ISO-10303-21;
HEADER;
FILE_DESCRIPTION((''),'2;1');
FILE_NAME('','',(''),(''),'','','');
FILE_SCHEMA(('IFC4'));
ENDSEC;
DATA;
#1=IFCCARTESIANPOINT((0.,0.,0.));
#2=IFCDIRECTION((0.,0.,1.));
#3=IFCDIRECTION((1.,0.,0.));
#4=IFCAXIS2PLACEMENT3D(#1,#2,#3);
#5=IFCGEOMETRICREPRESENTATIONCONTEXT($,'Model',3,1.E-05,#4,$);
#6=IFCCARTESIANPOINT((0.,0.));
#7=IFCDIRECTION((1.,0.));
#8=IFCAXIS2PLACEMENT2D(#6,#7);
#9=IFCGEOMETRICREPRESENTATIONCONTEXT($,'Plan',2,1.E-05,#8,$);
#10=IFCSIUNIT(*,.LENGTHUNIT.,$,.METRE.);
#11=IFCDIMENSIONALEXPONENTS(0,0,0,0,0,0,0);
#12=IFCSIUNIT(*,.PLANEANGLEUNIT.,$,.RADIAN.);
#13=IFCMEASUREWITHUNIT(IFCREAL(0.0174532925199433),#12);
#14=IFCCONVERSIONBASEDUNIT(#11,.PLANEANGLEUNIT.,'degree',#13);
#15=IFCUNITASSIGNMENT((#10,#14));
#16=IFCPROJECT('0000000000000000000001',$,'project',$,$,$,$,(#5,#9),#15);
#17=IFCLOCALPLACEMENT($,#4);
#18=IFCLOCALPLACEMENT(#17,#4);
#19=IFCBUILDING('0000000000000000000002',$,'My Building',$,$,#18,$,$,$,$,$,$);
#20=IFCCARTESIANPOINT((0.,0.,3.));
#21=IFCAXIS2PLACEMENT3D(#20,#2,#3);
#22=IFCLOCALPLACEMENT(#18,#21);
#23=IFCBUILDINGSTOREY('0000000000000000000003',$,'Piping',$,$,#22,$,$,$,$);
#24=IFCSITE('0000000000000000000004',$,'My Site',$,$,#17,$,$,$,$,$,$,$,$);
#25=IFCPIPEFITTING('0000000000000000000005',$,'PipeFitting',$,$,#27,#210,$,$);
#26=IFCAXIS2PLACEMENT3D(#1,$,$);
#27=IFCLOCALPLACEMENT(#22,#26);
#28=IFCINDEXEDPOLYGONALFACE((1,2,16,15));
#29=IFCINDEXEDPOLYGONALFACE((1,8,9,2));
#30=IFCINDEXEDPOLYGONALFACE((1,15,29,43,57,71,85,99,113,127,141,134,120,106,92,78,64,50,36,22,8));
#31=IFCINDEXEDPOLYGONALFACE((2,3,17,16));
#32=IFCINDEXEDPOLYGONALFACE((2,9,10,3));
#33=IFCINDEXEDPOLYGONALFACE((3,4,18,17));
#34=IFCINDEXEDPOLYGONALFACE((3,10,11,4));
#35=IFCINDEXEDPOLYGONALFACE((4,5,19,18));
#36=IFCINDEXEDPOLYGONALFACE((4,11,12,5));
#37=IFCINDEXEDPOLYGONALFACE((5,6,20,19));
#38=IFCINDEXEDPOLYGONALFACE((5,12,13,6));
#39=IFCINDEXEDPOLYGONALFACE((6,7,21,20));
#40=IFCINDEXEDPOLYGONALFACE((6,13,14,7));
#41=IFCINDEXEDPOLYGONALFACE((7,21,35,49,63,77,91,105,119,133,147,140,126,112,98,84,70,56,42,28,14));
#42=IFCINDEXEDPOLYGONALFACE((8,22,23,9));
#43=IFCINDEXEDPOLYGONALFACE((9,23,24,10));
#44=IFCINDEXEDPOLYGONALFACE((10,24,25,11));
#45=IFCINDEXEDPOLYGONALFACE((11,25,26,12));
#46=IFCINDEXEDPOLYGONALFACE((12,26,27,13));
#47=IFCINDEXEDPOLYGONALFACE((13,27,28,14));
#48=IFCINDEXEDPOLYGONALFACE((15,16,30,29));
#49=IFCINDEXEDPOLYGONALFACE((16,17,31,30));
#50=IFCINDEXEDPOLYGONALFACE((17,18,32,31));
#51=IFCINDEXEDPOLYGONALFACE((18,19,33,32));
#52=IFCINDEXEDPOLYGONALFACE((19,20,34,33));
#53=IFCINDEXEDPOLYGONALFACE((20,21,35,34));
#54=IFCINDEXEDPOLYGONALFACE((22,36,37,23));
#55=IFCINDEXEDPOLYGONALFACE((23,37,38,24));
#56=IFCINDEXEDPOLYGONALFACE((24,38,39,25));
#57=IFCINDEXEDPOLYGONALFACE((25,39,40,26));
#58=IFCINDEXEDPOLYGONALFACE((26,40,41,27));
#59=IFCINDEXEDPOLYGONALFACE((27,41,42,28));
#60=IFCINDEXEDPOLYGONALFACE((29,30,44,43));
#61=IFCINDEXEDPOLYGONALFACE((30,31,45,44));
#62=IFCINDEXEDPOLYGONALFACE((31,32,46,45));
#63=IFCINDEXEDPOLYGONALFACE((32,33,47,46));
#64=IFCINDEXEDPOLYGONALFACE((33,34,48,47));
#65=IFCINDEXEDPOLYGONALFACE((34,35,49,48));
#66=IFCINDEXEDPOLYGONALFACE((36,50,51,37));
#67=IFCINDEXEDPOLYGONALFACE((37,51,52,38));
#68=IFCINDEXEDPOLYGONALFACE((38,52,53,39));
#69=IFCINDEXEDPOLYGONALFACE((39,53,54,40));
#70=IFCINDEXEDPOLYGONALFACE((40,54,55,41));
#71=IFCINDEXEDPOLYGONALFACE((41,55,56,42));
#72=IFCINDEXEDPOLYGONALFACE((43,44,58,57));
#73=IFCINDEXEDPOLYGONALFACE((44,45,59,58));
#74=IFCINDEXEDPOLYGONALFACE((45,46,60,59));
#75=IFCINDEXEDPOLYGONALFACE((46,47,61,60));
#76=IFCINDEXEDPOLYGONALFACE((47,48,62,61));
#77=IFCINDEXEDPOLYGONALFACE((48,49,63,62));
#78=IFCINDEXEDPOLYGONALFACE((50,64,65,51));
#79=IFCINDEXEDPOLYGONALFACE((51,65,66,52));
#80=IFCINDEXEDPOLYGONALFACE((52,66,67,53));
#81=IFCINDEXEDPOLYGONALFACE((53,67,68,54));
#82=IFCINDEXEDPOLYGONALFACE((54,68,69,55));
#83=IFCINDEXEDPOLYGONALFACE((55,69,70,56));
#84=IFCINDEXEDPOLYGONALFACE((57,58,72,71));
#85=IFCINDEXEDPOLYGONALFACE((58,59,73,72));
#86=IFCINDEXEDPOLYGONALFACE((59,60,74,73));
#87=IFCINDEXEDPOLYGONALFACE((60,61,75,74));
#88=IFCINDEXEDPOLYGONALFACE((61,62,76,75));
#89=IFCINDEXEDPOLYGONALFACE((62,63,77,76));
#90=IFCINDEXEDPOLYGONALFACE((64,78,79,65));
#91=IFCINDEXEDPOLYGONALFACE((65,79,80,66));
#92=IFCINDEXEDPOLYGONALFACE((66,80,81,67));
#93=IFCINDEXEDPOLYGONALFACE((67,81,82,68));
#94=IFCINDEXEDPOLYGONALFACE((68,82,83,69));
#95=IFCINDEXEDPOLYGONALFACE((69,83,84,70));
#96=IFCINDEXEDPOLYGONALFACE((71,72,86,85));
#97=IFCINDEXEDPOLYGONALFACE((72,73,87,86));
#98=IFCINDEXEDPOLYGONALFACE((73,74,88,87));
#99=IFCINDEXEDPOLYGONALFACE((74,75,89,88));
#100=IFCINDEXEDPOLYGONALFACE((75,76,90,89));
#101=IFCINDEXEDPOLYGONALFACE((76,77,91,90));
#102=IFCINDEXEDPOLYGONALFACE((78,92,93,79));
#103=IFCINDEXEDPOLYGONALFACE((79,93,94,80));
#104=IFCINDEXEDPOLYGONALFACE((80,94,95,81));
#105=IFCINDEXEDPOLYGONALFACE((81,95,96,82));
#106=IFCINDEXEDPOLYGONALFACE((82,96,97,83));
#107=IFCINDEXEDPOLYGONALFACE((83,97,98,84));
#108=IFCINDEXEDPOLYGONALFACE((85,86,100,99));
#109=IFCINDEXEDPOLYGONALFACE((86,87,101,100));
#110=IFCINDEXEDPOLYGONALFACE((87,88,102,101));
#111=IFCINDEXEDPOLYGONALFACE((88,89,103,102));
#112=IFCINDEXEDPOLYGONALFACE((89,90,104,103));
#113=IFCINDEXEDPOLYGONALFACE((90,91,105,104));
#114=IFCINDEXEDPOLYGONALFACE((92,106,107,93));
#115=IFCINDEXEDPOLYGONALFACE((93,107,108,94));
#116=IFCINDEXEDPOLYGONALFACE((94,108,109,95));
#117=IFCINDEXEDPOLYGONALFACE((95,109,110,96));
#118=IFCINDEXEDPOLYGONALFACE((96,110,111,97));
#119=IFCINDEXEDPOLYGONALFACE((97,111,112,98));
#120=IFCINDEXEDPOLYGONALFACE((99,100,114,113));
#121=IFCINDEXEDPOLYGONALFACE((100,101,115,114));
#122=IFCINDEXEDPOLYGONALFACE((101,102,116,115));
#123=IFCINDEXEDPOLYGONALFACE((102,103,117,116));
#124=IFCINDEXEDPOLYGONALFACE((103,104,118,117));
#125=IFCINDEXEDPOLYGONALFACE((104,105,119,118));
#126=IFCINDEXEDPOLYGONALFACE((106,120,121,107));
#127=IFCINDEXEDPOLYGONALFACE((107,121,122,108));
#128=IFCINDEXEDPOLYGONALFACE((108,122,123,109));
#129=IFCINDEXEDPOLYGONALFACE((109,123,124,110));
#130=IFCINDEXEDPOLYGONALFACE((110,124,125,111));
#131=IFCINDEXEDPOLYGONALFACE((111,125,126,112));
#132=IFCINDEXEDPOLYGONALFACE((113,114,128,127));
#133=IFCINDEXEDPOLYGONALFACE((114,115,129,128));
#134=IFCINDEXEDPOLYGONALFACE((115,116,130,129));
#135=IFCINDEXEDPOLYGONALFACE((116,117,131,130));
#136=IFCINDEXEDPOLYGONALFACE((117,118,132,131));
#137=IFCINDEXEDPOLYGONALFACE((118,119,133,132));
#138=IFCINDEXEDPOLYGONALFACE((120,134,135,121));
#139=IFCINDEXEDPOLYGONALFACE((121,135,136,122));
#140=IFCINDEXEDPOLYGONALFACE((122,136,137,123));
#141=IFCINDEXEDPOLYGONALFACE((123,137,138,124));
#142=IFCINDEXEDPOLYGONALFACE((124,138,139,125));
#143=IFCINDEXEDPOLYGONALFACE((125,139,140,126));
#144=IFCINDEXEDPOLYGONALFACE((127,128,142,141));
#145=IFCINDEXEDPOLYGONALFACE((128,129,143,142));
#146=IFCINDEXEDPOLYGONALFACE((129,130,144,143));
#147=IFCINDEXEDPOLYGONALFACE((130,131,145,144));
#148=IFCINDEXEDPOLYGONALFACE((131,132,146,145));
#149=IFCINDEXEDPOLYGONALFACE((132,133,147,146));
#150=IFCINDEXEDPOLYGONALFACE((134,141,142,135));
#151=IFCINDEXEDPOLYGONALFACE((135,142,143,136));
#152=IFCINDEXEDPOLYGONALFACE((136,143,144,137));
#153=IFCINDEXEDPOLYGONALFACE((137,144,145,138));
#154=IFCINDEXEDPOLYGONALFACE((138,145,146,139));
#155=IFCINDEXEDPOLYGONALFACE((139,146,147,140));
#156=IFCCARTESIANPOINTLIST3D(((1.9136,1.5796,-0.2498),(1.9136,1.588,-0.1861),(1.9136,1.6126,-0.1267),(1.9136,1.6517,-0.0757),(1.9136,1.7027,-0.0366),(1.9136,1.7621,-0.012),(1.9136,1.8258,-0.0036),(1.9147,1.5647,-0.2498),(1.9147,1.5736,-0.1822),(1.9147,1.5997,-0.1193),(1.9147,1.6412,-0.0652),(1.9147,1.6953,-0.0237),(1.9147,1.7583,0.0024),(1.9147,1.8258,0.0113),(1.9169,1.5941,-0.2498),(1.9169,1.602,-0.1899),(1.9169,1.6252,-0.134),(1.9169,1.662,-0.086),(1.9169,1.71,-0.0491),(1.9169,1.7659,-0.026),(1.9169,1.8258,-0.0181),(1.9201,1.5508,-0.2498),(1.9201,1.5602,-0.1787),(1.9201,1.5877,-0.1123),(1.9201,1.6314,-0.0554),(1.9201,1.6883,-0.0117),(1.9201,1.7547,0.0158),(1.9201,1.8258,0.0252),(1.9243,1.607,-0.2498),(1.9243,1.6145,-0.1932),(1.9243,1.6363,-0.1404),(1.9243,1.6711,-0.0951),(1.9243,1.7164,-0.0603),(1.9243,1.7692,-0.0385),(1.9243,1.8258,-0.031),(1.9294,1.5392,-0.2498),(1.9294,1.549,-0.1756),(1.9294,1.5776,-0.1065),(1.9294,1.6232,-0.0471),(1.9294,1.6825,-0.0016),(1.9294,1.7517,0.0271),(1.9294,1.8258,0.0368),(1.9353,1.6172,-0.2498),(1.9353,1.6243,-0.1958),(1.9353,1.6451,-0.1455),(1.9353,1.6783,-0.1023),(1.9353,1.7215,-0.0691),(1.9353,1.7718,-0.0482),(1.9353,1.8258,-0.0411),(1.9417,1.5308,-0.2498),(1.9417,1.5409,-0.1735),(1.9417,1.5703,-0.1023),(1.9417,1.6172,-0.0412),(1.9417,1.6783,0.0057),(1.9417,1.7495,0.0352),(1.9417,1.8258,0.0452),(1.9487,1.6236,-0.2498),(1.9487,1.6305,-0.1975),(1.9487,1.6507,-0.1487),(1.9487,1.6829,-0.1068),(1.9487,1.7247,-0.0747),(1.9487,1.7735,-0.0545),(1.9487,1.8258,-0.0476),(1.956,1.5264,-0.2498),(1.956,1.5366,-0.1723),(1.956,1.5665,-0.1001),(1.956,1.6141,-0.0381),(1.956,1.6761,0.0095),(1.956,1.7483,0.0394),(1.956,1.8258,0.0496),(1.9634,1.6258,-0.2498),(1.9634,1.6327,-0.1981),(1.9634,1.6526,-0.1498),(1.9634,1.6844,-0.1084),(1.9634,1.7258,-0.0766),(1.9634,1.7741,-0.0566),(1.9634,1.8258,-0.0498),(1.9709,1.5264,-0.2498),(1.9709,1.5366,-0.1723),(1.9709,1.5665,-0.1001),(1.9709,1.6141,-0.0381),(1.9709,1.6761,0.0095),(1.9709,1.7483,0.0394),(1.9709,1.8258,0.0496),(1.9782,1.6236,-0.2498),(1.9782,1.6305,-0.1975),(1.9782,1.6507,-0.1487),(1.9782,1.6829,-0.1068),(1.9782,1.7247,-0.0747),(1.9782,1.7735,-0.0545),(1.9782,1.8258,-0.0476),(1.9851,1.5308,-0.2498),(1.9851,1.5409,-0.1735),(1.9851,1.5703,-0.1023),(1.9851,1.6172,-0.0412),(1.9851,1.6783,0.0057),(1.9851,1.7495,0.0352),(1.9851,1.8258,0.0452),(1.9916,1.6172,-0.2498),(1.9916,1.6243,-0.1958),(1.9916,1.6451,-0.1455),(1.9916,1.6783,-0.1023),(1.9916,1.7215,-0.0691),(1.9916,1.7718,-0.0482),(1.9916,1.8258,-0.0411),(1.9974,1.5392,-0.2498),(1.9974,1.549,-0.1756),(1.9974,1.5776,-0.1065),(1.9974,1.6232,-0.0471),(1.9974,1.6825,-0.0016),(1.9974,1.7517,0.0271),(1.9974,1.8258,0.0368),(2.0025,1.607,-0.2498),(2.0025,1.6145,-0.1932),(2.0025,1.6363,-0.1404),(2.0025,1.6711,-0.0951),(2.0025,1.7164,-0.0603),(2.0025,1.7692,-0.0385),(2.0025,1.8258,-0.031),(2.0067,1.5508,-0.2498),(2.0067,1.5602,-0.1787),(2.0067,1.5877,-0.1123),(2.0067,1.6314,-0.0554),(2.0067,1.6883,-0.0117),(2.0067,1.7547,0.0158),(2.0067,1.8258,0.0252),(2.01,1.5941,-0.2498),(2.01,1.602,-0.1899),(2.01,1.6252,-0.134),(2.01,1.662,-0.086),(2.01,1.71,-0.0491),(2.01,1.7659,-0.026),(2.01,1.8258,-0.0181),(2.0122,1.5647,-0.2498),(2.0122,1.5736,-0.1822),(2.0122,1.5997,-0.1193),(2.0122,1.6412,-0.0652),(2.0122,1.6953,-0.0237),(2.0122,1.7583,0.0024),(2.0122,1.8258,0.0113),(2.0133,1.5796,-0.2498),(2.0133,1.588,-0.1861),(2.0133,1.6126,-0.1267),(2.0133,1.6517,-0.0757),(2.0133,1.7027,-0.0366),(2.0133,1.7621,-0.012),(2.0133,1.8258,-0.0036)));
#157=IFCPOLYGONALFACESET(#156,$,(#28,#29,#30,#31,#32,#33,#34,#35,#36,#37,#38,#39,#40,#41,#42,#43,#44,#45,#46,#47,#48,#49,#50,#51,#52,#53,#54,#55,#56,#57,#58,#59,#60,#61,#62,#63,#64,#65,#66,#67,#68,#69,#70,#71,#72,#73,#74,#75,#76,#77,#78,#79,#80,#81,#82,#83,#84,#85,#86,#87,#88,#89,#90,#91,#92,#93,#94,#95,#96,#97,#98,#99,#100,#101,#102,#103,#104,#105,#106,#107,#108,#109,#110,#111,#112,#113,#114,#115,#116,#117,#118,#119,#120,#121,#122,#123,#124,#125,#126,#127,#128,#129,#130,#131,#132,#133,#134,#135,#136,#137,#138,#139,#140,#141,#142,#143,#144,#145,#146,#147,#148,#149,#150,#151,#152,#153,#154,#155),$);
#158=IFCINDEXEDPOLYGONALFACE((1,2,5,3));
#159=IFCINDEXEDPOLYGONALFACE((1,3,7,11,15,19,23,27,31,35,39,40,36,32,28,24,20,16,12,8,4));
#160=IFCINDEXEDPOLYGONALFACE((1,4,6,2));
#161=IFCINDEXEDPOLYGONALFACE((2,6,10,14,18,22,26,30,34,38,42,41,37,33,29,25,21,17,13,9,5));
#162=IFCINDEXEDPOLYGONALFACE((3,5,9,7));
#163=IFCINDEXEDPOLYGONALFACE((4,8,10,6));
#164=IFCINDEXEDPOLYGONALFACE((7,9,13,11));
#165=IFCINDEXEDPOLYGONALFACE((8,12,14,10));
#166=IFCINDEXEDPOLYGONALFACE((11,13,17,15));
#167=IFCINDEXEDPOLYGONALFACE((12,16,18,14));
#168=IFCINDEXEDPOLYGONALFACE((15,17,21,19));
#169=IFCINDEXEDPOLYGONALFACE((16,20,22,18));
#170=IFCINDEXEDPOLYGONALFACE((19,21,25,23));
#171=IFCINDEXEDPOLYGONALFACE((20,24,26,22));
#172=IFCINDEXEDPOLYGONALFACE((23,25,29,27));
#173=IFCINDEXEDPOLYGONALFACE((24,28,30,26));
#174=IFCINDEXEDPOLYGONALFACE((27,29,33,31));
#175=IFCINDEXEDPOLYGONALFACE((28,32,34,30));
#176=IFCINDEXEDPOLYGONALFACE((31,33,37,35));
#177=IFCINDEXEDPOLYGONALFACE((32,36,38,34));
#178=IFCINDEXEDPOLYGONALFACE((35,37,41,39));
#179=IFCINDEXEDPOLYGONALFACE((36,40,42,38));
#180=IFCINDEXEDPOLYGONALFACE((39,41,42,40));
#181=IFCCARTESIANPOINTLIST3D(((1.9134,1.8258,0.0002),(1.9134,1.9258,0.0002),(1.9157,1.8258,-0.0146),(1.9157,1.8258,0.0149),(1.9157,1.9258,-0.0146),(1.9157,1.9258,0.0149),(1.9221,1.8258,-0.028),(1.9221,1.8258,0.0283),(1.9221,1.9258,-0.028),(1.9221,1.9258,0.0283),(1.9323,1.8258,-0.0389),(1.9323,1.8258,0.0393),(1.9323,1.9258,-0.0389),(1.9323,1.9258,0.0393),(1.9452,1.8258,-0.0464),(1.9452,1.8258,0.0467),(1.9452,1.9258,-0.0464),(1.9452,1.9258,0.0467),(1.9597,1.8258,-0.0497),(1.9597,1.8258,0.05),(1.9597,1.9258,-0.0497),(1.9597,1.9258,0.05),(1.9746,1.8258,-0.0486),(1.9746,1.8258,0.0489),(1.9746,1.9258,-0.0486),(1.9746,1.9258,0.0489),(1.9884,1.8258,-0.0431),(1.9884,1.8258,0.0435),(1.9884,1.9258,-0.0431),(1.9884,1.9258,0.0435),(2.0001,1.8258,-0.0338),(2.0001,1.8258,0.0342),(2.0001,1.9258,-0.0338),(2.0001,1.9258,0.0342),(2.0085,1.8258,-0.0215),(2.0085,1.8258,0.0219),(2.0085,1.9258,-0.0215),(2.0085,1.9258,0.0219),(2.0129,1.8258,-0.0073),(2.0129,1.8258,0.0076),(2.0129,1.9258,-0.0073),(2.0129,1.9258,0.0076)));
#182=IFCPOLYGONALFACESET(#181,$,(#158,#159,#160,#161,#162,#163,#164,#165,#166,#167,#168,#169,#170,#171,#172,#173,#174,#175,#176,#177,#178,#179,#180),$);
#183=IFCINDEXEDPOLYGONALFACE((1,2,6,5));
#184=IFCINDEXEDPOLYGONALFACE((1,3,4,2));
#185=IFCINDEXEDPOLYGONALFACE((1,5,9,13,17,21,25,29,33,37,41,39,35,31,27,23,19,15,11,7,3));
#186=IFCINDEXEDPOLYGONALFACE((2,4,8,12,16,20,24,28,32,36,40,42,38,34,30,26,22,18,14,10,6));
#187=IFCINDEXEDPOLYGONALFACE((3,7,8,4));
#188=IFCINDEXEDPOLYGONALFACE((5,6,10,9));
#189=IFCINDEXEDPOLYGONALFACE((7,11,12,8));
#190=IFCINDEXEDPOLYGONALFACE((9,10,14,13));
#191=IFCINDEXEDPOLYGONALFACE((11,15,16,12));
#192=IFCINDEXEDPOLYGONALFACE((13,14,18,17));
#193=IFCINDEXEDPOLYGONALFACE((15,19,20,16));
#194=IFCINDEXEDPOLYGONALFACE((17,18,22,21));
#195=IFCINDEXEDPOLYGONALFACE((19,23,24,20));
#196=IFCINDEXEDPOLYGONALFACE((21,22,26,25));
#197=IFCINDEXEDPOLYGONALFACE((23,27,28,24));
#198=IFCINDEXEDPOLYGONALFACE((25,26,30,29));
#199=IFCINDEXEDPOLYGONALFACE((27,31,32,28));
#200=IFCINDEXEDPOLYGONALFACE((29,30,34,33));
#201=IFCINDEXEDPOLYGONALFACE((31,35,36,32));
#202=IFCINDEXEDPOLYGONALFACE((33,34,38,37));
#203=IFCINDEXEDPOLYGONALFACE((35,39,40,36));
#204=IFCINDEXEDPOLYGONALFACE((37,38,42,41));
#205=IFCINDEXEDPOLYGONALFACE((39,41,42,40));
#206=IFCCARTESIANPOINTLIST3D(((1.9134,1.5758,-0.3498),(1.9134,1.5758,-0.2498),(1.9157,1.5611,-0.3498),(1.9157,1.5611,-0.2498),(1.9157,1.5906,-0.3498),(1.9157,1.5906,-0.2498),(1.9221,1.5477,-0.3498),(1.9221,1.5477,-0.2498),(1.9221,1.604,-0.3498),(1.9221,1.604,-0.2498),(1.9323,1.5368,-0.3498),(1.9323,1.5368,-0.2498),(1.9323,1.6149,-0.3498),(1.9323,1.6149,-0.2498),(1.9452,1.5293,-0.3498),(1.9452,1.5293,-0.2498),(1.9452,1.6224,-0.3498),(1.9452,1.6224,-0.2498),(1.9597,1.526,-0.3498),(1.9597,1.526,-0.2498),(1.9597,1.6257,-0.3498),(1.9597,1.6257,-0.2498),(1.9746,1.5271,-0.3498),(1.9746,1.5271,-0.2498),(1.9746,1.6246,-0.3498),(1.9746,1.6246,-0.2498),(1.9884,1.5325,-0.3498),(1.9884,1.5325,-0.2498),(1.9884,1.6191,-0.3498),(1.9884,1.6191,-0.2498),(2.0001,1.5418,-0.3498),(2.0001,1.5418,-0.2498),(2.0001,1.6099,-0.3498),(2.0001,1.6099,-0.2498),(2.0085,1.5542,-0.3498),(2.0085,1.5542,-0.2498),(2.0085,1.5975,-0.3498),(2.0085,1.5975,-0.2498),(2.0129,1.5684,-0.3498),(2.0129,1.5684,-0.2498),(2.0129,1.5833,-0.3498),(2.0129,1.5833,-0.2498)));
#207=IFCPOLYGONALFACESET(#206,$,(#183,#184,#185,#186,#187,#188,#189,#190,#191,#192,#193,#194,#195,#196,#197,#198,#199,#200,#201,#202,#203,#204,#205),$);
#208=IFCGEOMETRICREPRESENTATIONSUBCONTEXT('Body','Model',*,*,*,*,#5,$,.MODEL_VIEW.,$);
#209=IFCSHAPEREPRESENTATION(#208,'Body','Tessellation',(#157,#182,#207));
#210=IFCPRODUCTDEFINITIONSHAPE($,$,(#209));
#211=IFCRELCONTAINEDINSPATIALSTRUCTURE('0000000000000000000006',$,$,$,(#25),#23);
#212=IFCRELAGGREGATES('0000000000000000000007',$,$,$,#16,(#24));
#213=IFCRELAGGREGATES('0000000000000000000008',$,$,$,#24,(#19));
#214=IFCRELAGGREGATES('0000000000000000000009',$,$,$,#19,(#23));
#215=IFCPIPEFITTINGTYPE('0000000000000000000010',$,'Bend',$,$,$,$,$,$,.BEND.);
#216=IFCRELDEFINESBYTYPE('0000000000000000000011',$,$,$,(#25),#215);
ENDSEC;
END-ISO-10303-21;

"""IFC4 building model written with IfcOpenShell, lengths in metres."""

from ifc_helpers import new_model, entity, si_unit, converted_unit, frame, origin_with_axes, origin_2d_with_axis, place, context, subcontext, project, spatial, circle, extrude, source, transform, mapped, type_object, type_shapes, element, save


model = new_model("IFC4")

# Units and contexts
model_context = context("Model", 3, precision=1e-05, world=origin_with_axes())
plan_context = context("Plan", 2, precision=1e-05, world=origin_2d_with_axis())
body_context = subcontext(model_context, "Body", "Model", "MODEL_VIEW")
ifc_project = project(units=[si_unit("LENGTHUNIT", "METRE"), converted_unit("PLANEANGLEUNIT", "degree", entity("IfcReal", 0.0174532925199433), si_unit("PLANEANGLEUNIT", "RADIAN"), dimensions=[0, 0, 0, 0, 0, 0, 0])], contexts=[model_context, plan_context])

# Site, building, storey
site_placement = place(None, origin_with_axes())
site = spatial("IfcSite", under=ifc_project, at=site_placement, Name="My Site")
building_placement = place(site_placement, origin_with_axes())
building = spatial("IfcBuilding", under=site, at=building_placement, Name="My Building")
storey_placement = place(building_placement, frame((0.0, 0.0, 3.0), z_axis=(0.0, 0.0, 1.0), x_axis=(1.0, 0.0, 0.0)))
storey = spatial("IfcBuildingStorey", under=building, at=storey_placement, Name="Piping")

# Pipe fitting
pipe_fitting_type = type_object("IfcPipeFittingType", Name="Bend", PredefinedType="BEND")
shared_shape = source(origin_with_axes(), body_context, "Body", "SolidModel", [
    entity("IfcSweptDiskSolid", entity("IfcIndexedPolyCurve", entity("IfcCartesianPointList3D", [[0.0, 0.0, -0.1], [0.0, -0.0732, -0.2768], [0.0, -0.25, -0.35]]), [entity("IfcArcIndex", [1, 2, 3])]), 0.05),
    extrude(circle(Radius=0.05), origin_with_axes(), (0.0, 0.0, -1.0), 0.1),
    extrude(circle(Radius=0.05), frame((0.0, -0.25, -0.35), z_axis=(0.0, -1.0, 0.0), x_axis=(1.0, 0.0, 0.0)), (0.0, 0.0, 1.0), 0.1),
])
type_shapes(pipe_fitting_type, [shared_shape])
for number, where, z_axis, x_axis, name in (
    (1, (1.9634, 1.9258, 0.0002), (0.0, 1.0, 0.0), (-1.0, 0.0, 0.0), "PipeFitting"),
):
    element("IfcPipeFitting", number, at=place(storey_placement, frame(where, z_axis=z_axis, x_axis=x_axis)), inside=storey, type_object=pipe_fitting_type, Name=name, context=body_context, shape_type="MappedRepresentation", body=[
        mapped(shared_shape, transform((0.0, 0.0, 0.0), x_axis=(1.0, 0.0, 0.0), y_axis=(0.0, 1.0, 0.0), z_axis=(0.0, 0.0, 1.0), scale=1.0)),
    ])

save(model, "model.ifc")
